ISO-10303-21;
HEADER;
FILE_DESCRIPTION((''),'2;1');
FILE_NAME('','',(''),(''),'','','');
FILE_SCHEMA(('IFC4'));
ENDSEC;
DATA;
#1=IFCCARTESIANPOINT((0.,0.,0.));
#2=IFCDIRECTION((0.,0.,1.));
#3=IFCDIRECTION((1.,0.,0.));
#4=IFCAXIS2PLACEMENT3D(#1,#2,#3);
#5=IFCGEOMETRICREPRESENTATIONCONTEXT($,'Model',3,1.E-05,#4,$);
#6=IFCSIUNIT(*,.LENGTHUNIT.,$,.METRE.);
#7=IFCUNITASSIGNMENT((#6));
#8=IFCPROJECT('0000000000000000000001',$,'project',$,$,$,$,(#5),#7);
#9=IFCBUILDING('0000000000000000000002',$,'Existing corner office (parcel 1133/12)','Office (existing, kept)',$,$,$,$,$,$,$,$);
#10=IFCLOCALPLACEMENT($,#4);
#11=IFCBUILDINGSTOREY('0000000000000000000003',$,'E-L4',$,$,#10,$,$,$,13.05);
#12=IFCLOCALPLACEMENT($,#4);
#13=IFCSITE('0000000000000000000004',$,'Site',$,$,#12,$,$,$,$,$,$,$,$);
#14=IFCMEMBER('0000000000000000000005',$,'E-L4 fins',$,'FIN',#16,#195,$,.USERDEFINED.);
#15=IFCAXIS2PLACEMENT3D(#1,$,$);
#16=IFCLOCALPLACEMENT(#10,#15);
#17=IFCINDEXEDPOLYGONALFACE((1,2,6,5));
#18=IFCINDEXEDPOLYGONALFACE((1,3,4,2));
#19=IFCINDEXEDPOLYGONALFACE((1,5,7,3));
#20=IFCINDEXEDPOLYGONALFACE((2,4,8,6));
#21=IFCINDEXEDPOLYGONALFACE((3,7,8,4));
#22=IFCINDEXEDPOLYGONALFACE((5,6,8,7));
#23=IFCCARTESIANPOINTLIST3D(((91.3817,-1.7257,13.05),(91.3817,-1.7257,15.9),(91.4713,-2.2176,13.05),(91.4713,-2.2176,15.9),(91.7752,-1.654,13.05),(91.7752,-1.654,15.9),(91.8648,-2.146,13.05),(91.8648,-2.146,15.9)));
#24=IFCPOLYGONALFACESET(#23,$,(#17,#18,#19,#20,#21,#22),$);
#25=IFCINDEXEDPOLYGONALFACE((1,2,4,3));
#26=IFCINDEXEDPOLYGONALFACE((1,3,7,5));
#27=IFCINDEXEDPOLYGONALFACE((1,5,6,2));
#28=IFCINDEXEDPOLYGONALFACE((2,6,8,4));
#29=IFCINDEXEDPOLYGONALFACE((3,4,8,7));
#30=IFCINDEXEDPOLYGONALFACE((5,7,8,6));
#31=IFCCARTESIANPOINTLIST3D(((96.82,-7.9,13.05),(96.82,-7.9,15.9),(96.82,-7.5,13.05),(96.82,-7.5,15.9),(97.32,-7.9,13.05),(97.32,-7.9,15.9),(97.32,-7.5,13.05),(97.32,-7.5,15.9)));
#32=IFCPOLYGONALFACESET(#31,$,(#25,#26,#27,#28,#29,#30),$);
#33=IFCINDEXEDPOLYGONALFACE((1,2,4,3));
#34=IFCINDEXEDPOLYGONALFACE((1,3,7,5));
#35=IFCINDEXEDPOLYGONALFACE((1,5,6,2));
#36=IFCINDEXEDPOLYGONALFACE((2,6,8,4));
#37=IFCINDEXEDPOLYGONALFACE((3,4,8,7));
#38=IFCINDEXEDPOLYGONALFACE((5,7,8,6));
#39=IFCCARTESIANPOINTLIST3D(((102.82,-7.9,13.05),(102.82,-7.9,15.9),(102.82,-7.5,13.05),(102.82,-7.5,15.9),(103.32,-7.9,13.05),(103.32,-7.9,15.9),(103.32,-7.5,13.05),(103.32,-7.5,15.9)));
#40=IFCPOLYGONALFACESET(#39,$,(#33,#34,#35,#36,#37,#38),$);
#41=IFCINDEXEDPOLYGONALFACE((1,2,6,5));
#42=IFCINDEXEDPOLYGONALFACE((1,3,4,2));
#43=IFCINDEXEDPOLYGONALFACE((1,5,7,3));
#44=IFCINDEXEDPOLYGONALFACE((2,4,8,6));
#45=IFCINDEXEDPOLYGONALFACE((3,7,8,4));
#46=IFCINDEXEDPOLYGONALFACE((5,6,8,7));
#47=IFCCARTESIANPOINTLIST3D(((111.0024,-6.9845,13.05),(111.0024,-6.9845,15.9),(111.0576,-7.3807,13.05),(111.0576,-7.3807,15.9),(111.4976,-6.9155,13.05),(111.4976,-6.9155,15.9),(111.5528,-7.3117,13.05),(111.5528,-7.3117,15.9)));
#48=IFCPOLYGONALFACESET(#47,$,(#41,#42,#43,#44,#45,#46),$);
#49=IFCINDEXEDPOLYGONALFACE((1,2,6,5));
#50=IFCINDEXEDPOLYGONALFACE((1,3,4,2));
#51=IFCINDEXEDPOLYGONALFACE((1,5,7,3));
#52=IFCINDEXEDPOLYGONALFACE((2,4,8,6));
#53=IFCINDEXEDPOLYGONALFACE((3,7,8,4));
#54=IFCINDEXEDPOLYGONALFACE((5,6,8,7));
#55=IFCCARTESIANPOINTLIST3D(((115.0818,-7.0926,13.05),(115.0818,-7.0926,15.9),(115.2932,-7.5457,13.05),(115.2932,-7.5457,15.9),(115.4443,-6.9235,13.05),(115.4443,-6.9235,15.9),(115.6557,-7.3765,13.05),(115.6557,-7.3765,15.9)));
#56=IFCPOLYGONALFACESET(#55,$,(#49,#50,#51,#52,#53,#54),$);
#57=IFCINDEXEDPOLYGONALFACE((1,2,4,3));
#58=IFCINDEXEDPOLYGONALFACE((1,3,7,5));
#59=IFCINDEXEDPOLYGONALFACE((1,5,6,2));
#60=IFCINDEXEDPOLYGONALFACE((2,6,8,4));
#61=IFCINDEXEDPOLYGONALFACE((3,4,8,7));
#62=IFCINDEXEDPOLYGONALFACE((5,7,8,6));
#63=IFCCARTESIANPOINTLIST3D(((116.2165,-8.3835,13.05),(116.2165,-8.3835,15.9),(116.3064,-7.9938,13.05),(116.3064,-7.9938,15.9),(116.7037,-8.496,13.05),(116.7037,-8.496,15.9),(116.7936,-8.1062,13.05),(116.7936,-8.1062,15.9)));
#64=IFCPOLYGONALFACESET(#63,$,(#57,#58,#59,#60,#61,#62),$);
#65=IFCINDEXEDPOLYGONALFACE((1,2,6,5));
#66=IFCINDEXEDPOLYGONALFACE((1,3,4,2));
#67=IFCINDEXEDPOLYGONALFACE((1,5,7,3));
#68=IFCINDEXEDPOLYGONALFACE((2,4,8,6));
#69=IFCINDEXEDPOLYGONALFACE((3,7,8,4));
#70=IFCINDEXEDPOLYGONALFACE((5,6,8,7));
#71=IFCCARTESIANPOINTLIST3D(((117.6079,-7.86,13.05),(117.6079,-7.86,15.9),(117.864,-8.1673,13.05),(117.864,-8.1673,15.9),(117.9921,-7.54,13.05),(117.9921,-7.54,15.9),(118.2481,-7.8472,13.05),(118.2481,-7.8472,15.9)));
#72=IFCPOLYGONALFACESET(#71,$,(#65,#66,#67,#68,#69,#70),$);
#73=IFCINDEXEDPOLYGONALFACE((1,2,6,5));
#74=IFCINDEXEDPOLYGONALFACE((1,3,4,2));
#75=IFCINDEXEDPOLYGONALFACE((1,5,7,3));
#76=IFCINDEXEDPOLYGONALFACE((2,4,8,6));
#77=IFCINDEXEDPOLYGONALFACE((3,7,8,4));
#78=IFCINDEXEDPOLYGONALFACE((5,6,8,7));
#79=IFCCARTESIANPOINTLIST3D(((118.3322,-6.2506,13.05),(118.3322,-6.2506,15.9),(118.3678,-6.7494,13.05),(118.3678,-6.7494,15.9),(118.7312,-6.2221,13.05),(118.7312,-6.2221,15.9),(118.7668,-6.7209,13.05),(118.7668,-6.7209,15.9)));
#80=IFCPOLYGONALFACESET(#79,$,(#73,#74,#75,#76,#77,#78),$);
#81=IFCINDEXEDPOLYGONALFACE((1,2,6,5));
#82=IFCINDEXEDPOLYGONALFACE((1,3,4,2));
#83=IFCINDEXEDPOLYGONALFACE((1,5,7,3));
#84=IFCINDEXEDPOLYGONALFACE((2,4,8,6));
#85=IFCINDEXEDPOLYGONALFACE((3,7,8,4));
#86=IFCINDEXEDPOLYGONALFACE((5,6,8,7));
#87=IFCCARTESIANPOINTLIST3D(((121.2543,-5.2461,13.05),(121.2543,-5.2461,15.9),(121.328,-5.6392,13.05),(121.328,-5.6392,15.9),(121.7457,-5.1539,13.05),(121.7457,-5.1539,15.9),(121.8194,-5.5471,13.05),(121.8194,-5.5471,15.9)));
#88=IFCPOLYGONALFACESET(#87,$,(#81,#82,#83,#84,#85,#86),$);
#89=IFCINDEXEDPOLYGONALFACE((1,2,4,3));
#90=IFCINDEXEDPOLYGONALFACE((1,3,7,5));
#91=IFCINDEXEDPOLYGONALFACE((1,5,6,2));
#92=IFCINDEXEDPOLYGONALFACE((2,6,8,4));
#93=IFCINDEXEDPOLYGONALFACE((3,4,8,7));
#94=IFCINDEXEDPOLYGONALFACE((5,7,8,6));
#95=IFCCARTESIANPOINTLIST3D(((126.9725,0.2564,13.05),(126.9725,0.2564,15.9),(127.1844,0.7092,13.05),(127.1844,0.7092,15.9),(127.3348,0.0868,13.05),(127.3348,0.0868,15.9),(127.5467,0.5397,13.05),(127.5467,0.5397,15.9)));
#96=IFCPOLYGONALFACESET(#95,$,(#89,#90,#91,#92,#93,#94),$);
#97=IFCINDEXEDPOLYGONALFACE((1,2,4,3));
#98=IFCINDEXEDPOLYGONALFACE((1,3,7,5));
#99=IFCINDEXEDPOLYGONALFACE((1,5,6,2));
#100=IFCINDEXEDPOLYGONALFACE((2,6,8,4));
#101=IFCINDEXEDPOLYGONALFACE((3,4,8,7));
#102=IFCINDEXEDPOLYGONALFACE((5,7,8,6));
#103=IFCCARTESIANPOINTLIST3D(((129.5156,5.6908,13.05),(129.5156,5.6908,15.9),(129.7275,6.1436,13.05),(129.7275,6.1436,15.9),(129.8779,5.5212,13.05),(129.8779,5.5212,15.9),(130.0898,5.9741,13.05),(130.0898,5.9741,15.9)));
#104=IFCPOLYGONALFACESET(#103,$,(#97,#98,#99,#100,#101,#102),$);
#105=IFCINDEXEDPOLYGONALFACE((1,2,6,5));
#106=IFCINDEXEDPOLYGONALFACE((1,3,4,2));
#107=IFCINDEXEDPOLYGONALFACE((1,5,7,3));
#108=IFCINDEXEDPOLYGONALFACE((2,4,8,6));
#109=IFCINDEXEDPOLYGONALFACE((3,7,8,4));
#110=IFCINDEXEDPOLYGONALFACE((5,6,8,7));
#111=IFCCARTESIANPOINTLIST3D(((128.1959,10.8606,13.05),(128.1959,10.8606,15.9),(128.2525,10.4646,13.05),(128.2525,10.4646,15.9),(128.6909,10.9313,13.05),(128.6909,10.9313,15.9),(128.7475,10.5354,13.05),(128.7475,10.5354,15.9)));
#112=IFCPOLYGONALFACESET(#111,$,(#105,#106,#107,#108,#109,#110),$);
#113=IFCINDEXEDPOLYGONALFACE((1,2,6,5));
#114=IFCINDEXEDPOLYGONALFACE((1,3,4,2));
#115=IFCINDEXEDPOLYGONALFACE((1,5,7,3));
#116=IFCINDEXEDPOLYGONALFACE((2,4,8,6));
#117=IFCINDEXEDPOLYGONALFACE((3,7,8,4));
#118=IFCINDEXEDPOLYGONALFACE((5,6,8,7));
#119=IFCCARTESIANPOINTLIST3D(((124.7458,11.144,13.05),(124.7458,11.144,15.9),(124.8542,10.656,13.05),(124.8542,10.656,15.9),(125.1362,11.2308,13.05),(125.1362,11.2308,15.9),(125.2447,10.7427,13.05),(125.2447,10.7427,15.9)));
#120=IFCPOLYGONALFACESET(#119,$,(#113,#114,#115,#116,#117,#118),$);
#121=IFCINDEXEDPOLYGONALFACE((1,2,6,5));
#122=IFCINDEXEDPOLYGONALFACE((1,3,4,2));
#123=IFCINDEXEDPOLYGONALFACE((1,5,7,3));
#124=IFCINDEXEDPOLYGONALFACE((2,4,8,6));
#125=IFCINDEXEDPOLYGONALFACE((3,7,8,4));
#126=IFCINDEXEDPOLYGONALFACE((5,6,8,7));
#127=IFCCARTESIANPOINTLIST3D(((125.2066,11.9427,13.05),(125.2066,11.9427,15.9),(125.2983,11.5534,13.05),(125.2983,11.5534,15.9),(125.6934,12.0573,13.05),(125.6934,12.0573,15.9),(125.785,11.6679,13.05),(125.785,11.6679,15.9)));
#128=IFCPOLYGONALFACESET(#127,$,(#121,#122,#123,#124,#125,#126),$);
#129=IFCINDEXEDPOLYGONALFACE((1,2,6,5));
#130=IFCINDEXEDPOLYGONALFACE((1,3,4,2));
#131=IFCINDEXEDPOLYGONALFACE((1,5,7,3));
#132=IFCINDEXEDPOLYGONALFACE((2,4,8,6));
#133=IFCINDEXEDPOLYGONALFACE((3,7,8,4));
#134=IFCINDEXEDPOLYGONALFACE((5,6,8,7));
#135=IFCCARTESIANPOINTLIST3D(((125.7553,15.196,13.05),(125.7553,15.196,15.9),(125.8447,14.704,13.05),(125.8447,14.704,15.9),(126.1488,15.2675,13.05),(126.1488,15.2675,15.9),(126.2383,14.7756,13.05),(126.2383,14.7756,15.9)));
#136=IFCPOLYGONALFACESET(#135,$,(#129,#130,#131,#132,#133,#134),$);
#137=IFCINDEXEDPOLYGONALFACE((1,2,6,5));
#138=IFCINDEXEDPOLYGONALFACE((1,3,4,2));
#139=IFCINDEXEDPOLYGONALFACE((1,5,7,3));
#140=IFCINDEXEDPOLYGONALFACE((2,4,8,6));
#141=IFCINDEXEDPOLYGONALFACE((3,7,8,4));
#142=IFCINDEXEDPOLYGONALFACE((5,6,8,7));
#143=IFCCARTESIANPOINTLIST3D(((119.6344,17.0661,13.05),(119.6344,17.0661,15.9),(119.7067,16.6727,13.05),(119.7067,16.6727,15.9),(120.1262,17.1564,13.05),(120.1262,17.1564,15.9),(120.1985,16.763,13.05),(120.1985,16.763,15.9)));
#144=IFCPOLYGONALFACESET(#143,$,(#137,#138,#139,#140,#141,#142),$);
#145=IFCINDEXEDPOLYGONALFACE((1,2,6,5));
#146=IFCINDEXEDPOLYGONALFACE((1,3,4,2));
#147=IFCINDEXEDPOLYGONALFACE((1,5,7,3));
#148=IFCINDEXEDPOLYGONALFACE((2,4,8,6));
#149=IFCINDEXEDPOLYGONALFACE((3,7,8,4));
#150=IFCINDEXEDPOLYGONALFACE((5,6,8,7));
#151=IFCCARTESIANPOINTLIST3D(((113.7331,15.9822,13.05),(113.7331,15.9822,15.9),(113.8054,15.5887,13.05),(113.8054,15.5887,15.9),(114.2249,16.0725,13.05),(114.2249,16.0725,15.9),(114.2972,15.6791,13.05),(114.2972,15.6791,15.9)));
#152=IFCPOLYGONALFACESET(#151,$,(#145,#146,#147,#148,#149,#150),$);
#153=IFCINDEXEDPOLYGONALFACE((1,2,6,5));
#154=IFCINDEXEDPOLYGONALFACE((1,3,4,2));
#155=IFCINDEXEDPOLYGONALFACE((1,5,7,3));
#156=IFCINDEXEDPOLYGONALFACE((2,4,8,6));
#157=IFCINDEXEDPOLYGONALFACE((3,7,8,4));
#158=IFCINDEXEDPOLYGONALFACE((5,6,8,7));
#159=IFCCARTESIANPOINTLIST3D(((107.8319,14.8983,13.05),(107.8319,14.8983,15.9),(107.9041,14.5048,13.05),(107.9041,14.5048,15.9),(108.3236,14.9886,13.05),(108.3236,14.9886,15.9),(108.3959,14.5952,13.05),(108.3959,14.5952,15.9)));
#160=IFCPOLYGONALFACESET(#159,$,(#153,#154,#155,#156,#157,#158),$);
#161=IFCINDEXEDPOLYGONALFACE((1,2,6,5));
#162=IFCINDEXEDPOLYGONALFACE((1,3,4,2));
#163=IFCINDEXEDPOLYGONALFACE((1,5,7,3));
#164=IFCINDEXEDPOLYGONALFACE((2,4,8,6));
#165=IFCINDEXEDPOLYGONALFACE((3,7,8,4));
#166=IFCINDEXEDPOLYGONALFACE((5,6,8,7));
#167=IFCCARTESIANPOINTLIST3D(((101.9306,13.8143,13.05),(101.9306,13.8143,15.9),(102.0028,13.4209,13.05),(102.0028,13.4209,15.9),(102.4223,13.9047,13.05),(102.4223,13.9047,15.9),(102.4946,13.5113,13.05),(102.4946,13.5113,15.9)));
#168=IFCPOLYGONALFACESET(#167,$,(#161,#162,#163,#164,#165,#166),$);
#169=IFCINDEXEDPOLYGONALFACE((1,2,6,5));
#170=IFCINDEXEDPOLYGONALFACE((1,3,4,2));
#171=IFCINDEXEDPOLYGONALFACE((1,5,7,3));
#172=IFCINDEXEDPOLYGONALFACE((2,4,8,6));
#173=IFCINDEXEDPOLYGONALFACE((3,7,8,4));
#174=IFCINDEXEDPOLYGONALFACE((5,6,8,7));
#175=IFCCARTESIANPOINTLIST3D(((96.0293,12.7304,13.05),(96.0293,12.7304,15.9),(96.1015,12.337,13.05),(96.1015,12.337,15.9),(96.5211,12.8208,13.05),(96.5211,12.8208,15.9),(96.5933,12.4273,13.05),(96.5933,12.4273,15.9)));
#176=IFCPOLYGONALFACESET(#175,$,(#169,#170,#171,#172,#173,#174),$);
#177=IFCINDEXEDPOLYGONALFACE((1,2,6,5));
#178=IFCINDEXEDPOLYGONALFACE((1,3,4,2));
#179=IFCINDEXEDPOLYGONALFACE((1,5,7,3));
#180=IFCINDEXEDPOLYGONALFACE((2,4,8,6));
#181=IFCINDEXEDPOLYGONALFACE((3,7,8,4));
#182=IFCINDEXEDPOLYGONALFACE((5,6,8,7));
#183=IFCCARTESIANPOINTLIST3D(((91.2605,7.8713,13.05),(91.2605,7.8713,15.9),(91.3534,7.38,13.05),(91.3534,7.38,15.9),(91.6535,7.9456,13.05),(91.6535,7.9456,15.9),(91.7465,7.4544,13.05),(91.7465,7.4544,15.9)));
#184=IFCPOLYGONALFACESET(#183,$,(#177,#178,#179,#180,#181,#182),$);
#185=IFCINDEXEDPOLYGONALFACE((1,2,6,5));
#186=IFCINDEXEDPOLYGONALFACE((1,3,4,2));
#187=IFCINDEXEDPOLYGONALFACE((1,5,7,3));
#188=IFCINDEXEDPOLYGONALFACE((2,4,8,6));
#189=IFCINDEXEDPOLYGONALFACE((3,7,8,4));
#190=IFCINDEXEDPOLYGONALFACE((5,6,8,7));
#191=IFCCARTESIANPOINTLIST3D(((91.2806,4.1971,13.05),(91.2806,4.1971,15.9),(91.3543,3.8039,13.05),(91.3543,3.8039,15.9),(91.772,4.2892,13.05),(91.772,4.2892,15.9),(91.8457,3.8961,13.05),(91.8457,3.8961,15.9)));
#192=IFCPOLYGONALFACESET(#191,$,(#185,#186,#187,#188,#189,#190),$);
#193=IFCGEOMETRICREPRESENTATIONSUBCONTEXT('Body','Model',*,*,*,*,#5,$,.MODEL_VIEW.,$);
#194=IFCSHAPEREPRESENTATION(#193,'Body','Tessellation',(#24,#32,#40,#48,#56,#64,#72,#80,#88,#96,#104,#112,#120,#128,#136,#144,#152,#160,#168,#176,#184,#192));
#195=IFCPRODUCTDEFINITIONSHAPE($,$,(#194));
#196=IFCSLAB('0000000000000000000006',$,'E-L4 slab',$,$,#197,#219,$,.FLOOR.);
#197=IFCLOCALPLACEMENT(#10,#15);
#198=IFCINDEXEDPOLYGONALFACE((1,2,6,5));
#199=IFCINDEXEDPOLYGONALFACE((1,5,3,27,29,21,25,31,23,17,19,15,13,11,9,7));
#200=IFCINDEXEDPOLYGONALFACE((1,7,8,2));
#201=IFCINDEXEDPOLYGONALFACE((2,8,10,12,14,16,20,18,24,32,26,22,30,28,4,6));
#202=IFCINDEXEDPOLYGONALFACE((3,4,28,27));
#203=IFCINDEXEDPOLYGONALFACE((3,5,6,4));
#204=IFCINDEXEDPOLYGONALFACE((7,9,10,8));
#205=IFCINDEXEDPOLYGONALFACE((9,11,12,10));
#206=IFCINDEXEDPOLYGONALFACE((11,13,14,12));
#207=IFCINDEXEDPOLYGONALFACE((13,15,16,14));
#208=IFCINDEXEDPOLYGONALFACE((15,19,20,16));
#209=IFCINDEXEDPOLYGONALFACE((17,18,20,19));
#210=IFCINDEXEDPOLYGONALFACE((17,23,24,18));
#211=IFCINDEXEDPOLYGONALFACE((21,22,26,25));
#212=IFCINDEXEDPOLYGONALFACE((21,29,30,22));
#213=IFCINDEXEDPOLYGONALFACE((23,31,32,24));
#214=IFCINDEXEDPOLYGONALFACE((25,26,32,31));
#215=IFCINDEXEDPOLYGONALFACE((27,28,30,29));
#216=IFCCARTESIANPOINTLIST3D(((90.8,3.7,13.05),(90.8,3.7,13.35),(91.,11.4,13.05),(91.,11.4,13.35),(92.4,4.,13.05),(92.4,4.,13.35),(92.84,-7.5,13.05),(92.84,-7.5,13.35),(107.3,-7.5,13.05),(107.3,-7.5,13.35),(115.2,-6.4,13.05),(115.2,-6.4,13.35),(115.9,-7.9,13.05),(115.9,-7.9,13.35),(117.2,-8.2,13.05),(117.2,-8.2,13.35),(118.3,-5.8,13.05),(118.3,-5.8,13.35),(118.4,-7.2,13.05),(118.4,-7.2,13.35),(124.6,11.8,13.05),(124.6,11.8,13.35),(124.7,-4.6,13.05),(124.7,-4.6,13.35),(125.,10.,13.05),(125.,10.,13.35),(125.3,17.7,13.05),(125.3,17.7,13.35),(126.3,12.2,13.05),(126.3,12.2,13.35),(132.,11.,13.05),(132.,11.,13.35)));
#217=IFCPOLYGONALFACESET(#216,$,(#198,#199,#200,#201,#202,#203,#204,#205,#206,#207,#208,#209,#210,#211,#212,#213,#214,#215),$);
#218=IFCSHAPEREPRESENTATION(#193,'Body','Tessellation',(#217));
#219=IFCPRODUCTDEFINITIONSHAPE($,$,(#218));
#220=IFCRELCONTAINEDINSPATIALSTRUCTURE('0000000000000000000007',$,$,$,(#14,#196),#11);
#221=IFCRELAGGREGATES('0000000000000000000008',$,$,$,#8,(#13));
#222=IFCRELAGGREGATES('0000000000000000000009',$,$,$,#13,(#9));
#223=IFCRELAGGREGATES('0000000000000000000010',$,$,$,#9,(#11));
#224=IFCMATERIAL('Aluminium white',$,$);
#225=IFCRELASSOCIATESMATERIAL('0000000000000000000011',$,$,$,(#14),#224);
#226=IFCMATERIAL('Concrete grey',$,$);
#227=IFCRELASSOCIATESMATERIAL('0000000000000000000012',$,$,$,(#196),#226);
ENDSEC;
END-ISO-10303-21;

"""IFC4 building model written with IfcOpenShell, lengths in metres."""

from ifc_helpers import new_model, si_unit, frame, origin_with_axes, place, context, subcontext, project, spatial, polyline, outline, extrude, material, element, save


model = new_model("IFC4")

# Units and contexts
model_context = context("Model", 3, precision=1e-05, world=origin_with_axes())
body_context = subcontext(model_context, "Body", "Model", "MODEL_VIEW")
ifc_project = project(units=[si_unit("LENGTHUNIT", "METRE")], contexts=[model_context])

# Site, building, storey
site_placement = place(None, origin_with_axes())
site = spatial("IfcSite", under=ifc_project, at=site_placement, Name="Site")
building = spatial("IfcBuilding", under=site, Name="Existing corner office (parcel 1133/12)", Description="Office (existing, kept)")
storey_placement = place(None, origin_with_axes())
storey = spatial("IfcBuildingStorey", under=building, at=storey_placement, Name="E-L4", Elevation=13.05)

# Member
ifc_material_1 = material(Name="Aluminium white")
member_1_placement = place(storey_placement, origin_with_axes())
element("IfcMember", 1, at=member_1_placement, inside=storey, material=ifc_material_1, Name="E-L4 fins", ObjectType="FIN", PredefinedType="USERDEFINED", context=body_context, shape_type="SweptSolid", body=[
    extrude(outline(polyline([(-0.2, -0.25), (0.2, -0.25), (0.2, 0.25), (-0.2, 0.25), (-0.2, -0.25)])), frame((91.6232, -1.9358, 13.05), z_axis=(0.0, 0.0, 1.0), x_axis=(-0.983814, -0.179195, 0.0)), (0.0, 0.0, 1.0), 2.85),
    extrude(outline(polyline([(-0.2, -0.25), (0.2, -0.25), (0.2, 0.25), (-0.2, 0.25), (-0.2, -0.25)])), frame((97.07, -7.7, 13.05), z_axis=(0.0, 0.0, 1.0), x_axis=(0.0, -1.0, 0.0)), (0.0, 0.0, 1.0), 2.85),
    extrude(outline(polyline([(-0.2, -0.25), (0.2, -0.25), (0.2, 0.25), (-0.2, 0.25), (-0.2, -0.25)])), frame((103.07, -7.7, 13.05), z_axis=(0.0, 0.0, 1.0), x_axis=(0.0, -1.0, 0.0)), (0.0, 0.0, 1.0), 2.85),
    extrude(outline(polyline([(-0.2, -0.25), (0.2, -0.25), (0.2, 0.25), (-0.2, 0.25), (-0.2, -0.25)])), frame((111.2776, -7.1481, 13.05), z_axis=(0.0, 0.0, 1.0), x_axis=(0.13791, -0.990445, 0.0)), (0.0, 0.0, 1.0), 2.85),
    extrude(outline(polyline([(-0.2, -0.25), (0.2, -0.25), (0.2, 0.25), (-0.2, 0.25), (-0.2, -0.25)])), frame((115.3688, -7.2346, 13.05), z_axis=(0.0, 0.0, 1.0), x_axis=(-0.906183, -0.422885, 0.0)), (0.0, 0.0, 1.0), 2.85),
    extrude(outline(polyline([(-0.2, -0.25), (0.2, -0.25), (0.2, 0.25), (-0.2, 0.25), (-0.2, -0.25)])), frame((116.505, -8.2449, 13.05), z_axis=(0.0, 0.0, 1.0), x_axis=(-0.22486, -0.974391, 0.0)), (0.0, 0.0, 1.0), 2.85),
    extrude(outline(polyline([(-0.2, -0.25), (0.2, -0.25), (0.2, 0.25), (-0.2, 0.25), (-0.2, -0.25)])), frame((117.928, -7.8536, 13.05), z_axis=(0.0, 0.0, 1.0), x_axis=(0.640184, -0.768221, 0.0)), (0.0, 0.0, 1.0), 2.85),
    extrude(outline(polyline([(-0.2, -0.25), (0.2, -0.25), (0.2, 0.25), (-0.2, 0.25), (-0.2, -0.25)])), frame((118.5495, -6.4858, 13.05), z_axis=(0.0, 0.0, 1.0), x_axis=(0.997459, 0.071247, 0.0)), (0.0, 0.0, 1.0), 2.85),
    extrude(outline(polyline([(-0.2, -0.25), (0.2, -0.25), (0.2, 0.25), (-0.2, 0.25), (-0.2, -0.25)])), frame((121.5369, -5.3966, 13.05), z_axis=(0.0, 0.0, 1.0), x_axis=(0.184289, -0.982872, 0.0)), (0.0, 0.0, 1.0), 2.85),
    extrude(outline(polyline([(-0.2, -0.25), (0.2, -0.25), (0.2, 0.25), (-0.2, 0.25), (-0.2, -0.25)])), frame((127.2596, 0.398, 13.05), z_axis=(0.0, 0.0, 1.0), x_axis=(0.905738, -0.423839, 0.0)), (0.0, 0.0, 1.0), 2.85),
    extrude(outline(polyline([(-0.2, -0.25), (0.2, -0.25), (0.2, 0.25), (-0.2, 0.25), (-0.2, -0.25)])), frame((129.8027, 5.8324, 13.05), z_axis=(0.0, 0.0, 1.0), x_axis=(0.905738, -0.423839, 0.0)), (0.0, 0.0, 1.0), 2.85),
    extrude(outline(polyline([(-0.2, -0.25), (0.2, -0.25), (0.2, 0.25), (-0.2, 0.25), (-0.2, -0.25)])), frame((128.4717, 10.698, 13.05), z_axis=(0.0, 0.0, 1.0), x_axis=(-0.141421, 0.989949, 0.0)), (0.0, 0.0, 1.0), 2.85),
    extrude(outline(polyline([(-0.2, -0.25), (0.2, -0.25), (0.2, 0.25), (-0.2, 0.25), (-0.2, -0.25)])), frame((124.9952, 10.9434, 13.05), z_axis=(0.0, 0.0, 1.0), x_axis=(0.976187, 0.21693, 0.0)), (0.0, 0.0, 1.0), 2.85),
    extrude(outline(polyline([(-0.2, -0.25), (0.2, -0.25), (0.2, 0.25), (-0.2, 0.25), (-0.2, -0.25)])), frame((125.4958, 11.8053, 13.05), z_axis=(0.0, 0.0, 1.0), x_axis=(0.229039, -0.973417, 0.0)), (0.0, 0.0, 1.0), 2.85),
    extrude(outline(polyline([(-0.2, -0.25), (0.2, -0.25), (0.2, 0.25), (-0.2, 0.25), (-0.2, -0.25)])), frame((125.9968, 14.9858, 13.05), z_axis=(0.0, 0.0, 1.0), x_axis=(0.98387, 0.178885, 0.0)), (0.0, 0.0, 1.0), 2.85),
    extrude(outline(polyline([(-0.2, -0.25), (0.2, -0.25), (0.2, 0.25), (-0.2, 0.25), (-0.2, -0.25)])), frame((119.9164, 16.9145, 13.05), z_axis=(0.0, 0.0, 1.0), x_axis=(-0.180652, 0.983547, 0.0)), (0.0, 0.0, 1.0), 2.85),
    extrude(outline(polyline([(-0.2, -0.25), (0.2, -0.25), (0.2, 0.25), (-0.2, 0.25), (-0.2, -0.25)])), frame((114.0152, 15.8306, 13.05), z_axis=(0.0, 0.0, 1.0), x_axis=(-0.180652, 0.983547, 0.0)), (0.0, 0.0, 1.0), 2.85),
    extrude(outline(polyline([(-0.2, -0.25), (0.2, -0.25), (0.2, 0.25), (-0.2, 0.25), (-0.2, -0.25)])), frame((108.1139, 14.7467, 13.05), z_axis=(0.0, 0.0, 1.0), x_axis=(-0.180652, 0.983547, 0.0)), (0.0, 0.0, 1.0), 2.85),
    extrude(outline(polyline([(-0.2, -0.25), (0.2, -0.25), (0.2, 0.25), (-0.2, 0.25), (-0.2, -0.25)])), frame((102.2126, 13.6628, 13.05), z_axis=(0.0, 0.0, 1.0), x_axis=(-0.180652, 0.983547, 0.0)), (0.0, 0.0, 1.0), 2.85),
    extrude(outline(polyline([(-0.2, -0.25), (0.2, -0.25), (0.2, 0.25), (-0.2, 0.25), (-0.2, -0.25)])), frame((96.3113, 12.5789, 13.05), z_axis=(0.0, 0.0, 1.0), x_axis=(-0.180652, 0.983547, 0.0)), (0.0, 0.0, 1.0), 2.85),
    extrude(outline(polyline([(-0.2, -0.25), (0.2, -0.25), (0.2, 0.25), (-0.2, 0.25), (-0.2, -0.25)])), frame((91.5035, 7.6628, 13.05), z_axis=(0.0, 0.0, 1.0), x_axis=(-0.98257, -0.185892, 0.0)), (0.0, 0.0, 1.0), 2.85),
    extrude(outline(polyline([(-0.2, -0.25), (0.2, -0.25), (0.2, 0.25), (-0.2, 0.25), (-0.2, -0.25)])), frame((91.5631, 4.0466, 13.05), z_axis=(0.0, 0.0, 1.0), x_axis=(-0.184289, 0.982872, 0.0)), (0.0, 0.0, 1.0), 2.85),
])

# Slab
ifc_material_2 = material(Name="Concrete grey")
slab_1_placement = place(storey_placement, origin_with_axes())
element("IfcSlab", 2, at=slab_1_placement, inside=storey, material=ifc_material_2, Name="E-L4 slab", PredefinedType="FLOOR", context=body_context, shape_type="SweptSolid", body=[
    extrude(outline(polyline([(90.8, 3.7), (92.84, -7.5), (107.3, -7.5), (115.2, -6.4), (115.9, -7.9), (117.2, -8.2), (118.4, -7.2), (118.3, -5.8), (124.7, -4.6), (132.0, 11.0), (125.0, 10.0), (124.6, 11.8), (126.3, 12.2), (125.3, 17.7), (91.0, 11.4), (92.4, 4.0), (90.8, 3.7)])), frame((0.0, 0.0, 13.05), z_axis=(0.0, 0.0, 1.0), x_axis=(1.0, 0.0, 0.0)), (0.0, 0.0, 1.0), 0.3),
])

save(model, "model.ifc")
